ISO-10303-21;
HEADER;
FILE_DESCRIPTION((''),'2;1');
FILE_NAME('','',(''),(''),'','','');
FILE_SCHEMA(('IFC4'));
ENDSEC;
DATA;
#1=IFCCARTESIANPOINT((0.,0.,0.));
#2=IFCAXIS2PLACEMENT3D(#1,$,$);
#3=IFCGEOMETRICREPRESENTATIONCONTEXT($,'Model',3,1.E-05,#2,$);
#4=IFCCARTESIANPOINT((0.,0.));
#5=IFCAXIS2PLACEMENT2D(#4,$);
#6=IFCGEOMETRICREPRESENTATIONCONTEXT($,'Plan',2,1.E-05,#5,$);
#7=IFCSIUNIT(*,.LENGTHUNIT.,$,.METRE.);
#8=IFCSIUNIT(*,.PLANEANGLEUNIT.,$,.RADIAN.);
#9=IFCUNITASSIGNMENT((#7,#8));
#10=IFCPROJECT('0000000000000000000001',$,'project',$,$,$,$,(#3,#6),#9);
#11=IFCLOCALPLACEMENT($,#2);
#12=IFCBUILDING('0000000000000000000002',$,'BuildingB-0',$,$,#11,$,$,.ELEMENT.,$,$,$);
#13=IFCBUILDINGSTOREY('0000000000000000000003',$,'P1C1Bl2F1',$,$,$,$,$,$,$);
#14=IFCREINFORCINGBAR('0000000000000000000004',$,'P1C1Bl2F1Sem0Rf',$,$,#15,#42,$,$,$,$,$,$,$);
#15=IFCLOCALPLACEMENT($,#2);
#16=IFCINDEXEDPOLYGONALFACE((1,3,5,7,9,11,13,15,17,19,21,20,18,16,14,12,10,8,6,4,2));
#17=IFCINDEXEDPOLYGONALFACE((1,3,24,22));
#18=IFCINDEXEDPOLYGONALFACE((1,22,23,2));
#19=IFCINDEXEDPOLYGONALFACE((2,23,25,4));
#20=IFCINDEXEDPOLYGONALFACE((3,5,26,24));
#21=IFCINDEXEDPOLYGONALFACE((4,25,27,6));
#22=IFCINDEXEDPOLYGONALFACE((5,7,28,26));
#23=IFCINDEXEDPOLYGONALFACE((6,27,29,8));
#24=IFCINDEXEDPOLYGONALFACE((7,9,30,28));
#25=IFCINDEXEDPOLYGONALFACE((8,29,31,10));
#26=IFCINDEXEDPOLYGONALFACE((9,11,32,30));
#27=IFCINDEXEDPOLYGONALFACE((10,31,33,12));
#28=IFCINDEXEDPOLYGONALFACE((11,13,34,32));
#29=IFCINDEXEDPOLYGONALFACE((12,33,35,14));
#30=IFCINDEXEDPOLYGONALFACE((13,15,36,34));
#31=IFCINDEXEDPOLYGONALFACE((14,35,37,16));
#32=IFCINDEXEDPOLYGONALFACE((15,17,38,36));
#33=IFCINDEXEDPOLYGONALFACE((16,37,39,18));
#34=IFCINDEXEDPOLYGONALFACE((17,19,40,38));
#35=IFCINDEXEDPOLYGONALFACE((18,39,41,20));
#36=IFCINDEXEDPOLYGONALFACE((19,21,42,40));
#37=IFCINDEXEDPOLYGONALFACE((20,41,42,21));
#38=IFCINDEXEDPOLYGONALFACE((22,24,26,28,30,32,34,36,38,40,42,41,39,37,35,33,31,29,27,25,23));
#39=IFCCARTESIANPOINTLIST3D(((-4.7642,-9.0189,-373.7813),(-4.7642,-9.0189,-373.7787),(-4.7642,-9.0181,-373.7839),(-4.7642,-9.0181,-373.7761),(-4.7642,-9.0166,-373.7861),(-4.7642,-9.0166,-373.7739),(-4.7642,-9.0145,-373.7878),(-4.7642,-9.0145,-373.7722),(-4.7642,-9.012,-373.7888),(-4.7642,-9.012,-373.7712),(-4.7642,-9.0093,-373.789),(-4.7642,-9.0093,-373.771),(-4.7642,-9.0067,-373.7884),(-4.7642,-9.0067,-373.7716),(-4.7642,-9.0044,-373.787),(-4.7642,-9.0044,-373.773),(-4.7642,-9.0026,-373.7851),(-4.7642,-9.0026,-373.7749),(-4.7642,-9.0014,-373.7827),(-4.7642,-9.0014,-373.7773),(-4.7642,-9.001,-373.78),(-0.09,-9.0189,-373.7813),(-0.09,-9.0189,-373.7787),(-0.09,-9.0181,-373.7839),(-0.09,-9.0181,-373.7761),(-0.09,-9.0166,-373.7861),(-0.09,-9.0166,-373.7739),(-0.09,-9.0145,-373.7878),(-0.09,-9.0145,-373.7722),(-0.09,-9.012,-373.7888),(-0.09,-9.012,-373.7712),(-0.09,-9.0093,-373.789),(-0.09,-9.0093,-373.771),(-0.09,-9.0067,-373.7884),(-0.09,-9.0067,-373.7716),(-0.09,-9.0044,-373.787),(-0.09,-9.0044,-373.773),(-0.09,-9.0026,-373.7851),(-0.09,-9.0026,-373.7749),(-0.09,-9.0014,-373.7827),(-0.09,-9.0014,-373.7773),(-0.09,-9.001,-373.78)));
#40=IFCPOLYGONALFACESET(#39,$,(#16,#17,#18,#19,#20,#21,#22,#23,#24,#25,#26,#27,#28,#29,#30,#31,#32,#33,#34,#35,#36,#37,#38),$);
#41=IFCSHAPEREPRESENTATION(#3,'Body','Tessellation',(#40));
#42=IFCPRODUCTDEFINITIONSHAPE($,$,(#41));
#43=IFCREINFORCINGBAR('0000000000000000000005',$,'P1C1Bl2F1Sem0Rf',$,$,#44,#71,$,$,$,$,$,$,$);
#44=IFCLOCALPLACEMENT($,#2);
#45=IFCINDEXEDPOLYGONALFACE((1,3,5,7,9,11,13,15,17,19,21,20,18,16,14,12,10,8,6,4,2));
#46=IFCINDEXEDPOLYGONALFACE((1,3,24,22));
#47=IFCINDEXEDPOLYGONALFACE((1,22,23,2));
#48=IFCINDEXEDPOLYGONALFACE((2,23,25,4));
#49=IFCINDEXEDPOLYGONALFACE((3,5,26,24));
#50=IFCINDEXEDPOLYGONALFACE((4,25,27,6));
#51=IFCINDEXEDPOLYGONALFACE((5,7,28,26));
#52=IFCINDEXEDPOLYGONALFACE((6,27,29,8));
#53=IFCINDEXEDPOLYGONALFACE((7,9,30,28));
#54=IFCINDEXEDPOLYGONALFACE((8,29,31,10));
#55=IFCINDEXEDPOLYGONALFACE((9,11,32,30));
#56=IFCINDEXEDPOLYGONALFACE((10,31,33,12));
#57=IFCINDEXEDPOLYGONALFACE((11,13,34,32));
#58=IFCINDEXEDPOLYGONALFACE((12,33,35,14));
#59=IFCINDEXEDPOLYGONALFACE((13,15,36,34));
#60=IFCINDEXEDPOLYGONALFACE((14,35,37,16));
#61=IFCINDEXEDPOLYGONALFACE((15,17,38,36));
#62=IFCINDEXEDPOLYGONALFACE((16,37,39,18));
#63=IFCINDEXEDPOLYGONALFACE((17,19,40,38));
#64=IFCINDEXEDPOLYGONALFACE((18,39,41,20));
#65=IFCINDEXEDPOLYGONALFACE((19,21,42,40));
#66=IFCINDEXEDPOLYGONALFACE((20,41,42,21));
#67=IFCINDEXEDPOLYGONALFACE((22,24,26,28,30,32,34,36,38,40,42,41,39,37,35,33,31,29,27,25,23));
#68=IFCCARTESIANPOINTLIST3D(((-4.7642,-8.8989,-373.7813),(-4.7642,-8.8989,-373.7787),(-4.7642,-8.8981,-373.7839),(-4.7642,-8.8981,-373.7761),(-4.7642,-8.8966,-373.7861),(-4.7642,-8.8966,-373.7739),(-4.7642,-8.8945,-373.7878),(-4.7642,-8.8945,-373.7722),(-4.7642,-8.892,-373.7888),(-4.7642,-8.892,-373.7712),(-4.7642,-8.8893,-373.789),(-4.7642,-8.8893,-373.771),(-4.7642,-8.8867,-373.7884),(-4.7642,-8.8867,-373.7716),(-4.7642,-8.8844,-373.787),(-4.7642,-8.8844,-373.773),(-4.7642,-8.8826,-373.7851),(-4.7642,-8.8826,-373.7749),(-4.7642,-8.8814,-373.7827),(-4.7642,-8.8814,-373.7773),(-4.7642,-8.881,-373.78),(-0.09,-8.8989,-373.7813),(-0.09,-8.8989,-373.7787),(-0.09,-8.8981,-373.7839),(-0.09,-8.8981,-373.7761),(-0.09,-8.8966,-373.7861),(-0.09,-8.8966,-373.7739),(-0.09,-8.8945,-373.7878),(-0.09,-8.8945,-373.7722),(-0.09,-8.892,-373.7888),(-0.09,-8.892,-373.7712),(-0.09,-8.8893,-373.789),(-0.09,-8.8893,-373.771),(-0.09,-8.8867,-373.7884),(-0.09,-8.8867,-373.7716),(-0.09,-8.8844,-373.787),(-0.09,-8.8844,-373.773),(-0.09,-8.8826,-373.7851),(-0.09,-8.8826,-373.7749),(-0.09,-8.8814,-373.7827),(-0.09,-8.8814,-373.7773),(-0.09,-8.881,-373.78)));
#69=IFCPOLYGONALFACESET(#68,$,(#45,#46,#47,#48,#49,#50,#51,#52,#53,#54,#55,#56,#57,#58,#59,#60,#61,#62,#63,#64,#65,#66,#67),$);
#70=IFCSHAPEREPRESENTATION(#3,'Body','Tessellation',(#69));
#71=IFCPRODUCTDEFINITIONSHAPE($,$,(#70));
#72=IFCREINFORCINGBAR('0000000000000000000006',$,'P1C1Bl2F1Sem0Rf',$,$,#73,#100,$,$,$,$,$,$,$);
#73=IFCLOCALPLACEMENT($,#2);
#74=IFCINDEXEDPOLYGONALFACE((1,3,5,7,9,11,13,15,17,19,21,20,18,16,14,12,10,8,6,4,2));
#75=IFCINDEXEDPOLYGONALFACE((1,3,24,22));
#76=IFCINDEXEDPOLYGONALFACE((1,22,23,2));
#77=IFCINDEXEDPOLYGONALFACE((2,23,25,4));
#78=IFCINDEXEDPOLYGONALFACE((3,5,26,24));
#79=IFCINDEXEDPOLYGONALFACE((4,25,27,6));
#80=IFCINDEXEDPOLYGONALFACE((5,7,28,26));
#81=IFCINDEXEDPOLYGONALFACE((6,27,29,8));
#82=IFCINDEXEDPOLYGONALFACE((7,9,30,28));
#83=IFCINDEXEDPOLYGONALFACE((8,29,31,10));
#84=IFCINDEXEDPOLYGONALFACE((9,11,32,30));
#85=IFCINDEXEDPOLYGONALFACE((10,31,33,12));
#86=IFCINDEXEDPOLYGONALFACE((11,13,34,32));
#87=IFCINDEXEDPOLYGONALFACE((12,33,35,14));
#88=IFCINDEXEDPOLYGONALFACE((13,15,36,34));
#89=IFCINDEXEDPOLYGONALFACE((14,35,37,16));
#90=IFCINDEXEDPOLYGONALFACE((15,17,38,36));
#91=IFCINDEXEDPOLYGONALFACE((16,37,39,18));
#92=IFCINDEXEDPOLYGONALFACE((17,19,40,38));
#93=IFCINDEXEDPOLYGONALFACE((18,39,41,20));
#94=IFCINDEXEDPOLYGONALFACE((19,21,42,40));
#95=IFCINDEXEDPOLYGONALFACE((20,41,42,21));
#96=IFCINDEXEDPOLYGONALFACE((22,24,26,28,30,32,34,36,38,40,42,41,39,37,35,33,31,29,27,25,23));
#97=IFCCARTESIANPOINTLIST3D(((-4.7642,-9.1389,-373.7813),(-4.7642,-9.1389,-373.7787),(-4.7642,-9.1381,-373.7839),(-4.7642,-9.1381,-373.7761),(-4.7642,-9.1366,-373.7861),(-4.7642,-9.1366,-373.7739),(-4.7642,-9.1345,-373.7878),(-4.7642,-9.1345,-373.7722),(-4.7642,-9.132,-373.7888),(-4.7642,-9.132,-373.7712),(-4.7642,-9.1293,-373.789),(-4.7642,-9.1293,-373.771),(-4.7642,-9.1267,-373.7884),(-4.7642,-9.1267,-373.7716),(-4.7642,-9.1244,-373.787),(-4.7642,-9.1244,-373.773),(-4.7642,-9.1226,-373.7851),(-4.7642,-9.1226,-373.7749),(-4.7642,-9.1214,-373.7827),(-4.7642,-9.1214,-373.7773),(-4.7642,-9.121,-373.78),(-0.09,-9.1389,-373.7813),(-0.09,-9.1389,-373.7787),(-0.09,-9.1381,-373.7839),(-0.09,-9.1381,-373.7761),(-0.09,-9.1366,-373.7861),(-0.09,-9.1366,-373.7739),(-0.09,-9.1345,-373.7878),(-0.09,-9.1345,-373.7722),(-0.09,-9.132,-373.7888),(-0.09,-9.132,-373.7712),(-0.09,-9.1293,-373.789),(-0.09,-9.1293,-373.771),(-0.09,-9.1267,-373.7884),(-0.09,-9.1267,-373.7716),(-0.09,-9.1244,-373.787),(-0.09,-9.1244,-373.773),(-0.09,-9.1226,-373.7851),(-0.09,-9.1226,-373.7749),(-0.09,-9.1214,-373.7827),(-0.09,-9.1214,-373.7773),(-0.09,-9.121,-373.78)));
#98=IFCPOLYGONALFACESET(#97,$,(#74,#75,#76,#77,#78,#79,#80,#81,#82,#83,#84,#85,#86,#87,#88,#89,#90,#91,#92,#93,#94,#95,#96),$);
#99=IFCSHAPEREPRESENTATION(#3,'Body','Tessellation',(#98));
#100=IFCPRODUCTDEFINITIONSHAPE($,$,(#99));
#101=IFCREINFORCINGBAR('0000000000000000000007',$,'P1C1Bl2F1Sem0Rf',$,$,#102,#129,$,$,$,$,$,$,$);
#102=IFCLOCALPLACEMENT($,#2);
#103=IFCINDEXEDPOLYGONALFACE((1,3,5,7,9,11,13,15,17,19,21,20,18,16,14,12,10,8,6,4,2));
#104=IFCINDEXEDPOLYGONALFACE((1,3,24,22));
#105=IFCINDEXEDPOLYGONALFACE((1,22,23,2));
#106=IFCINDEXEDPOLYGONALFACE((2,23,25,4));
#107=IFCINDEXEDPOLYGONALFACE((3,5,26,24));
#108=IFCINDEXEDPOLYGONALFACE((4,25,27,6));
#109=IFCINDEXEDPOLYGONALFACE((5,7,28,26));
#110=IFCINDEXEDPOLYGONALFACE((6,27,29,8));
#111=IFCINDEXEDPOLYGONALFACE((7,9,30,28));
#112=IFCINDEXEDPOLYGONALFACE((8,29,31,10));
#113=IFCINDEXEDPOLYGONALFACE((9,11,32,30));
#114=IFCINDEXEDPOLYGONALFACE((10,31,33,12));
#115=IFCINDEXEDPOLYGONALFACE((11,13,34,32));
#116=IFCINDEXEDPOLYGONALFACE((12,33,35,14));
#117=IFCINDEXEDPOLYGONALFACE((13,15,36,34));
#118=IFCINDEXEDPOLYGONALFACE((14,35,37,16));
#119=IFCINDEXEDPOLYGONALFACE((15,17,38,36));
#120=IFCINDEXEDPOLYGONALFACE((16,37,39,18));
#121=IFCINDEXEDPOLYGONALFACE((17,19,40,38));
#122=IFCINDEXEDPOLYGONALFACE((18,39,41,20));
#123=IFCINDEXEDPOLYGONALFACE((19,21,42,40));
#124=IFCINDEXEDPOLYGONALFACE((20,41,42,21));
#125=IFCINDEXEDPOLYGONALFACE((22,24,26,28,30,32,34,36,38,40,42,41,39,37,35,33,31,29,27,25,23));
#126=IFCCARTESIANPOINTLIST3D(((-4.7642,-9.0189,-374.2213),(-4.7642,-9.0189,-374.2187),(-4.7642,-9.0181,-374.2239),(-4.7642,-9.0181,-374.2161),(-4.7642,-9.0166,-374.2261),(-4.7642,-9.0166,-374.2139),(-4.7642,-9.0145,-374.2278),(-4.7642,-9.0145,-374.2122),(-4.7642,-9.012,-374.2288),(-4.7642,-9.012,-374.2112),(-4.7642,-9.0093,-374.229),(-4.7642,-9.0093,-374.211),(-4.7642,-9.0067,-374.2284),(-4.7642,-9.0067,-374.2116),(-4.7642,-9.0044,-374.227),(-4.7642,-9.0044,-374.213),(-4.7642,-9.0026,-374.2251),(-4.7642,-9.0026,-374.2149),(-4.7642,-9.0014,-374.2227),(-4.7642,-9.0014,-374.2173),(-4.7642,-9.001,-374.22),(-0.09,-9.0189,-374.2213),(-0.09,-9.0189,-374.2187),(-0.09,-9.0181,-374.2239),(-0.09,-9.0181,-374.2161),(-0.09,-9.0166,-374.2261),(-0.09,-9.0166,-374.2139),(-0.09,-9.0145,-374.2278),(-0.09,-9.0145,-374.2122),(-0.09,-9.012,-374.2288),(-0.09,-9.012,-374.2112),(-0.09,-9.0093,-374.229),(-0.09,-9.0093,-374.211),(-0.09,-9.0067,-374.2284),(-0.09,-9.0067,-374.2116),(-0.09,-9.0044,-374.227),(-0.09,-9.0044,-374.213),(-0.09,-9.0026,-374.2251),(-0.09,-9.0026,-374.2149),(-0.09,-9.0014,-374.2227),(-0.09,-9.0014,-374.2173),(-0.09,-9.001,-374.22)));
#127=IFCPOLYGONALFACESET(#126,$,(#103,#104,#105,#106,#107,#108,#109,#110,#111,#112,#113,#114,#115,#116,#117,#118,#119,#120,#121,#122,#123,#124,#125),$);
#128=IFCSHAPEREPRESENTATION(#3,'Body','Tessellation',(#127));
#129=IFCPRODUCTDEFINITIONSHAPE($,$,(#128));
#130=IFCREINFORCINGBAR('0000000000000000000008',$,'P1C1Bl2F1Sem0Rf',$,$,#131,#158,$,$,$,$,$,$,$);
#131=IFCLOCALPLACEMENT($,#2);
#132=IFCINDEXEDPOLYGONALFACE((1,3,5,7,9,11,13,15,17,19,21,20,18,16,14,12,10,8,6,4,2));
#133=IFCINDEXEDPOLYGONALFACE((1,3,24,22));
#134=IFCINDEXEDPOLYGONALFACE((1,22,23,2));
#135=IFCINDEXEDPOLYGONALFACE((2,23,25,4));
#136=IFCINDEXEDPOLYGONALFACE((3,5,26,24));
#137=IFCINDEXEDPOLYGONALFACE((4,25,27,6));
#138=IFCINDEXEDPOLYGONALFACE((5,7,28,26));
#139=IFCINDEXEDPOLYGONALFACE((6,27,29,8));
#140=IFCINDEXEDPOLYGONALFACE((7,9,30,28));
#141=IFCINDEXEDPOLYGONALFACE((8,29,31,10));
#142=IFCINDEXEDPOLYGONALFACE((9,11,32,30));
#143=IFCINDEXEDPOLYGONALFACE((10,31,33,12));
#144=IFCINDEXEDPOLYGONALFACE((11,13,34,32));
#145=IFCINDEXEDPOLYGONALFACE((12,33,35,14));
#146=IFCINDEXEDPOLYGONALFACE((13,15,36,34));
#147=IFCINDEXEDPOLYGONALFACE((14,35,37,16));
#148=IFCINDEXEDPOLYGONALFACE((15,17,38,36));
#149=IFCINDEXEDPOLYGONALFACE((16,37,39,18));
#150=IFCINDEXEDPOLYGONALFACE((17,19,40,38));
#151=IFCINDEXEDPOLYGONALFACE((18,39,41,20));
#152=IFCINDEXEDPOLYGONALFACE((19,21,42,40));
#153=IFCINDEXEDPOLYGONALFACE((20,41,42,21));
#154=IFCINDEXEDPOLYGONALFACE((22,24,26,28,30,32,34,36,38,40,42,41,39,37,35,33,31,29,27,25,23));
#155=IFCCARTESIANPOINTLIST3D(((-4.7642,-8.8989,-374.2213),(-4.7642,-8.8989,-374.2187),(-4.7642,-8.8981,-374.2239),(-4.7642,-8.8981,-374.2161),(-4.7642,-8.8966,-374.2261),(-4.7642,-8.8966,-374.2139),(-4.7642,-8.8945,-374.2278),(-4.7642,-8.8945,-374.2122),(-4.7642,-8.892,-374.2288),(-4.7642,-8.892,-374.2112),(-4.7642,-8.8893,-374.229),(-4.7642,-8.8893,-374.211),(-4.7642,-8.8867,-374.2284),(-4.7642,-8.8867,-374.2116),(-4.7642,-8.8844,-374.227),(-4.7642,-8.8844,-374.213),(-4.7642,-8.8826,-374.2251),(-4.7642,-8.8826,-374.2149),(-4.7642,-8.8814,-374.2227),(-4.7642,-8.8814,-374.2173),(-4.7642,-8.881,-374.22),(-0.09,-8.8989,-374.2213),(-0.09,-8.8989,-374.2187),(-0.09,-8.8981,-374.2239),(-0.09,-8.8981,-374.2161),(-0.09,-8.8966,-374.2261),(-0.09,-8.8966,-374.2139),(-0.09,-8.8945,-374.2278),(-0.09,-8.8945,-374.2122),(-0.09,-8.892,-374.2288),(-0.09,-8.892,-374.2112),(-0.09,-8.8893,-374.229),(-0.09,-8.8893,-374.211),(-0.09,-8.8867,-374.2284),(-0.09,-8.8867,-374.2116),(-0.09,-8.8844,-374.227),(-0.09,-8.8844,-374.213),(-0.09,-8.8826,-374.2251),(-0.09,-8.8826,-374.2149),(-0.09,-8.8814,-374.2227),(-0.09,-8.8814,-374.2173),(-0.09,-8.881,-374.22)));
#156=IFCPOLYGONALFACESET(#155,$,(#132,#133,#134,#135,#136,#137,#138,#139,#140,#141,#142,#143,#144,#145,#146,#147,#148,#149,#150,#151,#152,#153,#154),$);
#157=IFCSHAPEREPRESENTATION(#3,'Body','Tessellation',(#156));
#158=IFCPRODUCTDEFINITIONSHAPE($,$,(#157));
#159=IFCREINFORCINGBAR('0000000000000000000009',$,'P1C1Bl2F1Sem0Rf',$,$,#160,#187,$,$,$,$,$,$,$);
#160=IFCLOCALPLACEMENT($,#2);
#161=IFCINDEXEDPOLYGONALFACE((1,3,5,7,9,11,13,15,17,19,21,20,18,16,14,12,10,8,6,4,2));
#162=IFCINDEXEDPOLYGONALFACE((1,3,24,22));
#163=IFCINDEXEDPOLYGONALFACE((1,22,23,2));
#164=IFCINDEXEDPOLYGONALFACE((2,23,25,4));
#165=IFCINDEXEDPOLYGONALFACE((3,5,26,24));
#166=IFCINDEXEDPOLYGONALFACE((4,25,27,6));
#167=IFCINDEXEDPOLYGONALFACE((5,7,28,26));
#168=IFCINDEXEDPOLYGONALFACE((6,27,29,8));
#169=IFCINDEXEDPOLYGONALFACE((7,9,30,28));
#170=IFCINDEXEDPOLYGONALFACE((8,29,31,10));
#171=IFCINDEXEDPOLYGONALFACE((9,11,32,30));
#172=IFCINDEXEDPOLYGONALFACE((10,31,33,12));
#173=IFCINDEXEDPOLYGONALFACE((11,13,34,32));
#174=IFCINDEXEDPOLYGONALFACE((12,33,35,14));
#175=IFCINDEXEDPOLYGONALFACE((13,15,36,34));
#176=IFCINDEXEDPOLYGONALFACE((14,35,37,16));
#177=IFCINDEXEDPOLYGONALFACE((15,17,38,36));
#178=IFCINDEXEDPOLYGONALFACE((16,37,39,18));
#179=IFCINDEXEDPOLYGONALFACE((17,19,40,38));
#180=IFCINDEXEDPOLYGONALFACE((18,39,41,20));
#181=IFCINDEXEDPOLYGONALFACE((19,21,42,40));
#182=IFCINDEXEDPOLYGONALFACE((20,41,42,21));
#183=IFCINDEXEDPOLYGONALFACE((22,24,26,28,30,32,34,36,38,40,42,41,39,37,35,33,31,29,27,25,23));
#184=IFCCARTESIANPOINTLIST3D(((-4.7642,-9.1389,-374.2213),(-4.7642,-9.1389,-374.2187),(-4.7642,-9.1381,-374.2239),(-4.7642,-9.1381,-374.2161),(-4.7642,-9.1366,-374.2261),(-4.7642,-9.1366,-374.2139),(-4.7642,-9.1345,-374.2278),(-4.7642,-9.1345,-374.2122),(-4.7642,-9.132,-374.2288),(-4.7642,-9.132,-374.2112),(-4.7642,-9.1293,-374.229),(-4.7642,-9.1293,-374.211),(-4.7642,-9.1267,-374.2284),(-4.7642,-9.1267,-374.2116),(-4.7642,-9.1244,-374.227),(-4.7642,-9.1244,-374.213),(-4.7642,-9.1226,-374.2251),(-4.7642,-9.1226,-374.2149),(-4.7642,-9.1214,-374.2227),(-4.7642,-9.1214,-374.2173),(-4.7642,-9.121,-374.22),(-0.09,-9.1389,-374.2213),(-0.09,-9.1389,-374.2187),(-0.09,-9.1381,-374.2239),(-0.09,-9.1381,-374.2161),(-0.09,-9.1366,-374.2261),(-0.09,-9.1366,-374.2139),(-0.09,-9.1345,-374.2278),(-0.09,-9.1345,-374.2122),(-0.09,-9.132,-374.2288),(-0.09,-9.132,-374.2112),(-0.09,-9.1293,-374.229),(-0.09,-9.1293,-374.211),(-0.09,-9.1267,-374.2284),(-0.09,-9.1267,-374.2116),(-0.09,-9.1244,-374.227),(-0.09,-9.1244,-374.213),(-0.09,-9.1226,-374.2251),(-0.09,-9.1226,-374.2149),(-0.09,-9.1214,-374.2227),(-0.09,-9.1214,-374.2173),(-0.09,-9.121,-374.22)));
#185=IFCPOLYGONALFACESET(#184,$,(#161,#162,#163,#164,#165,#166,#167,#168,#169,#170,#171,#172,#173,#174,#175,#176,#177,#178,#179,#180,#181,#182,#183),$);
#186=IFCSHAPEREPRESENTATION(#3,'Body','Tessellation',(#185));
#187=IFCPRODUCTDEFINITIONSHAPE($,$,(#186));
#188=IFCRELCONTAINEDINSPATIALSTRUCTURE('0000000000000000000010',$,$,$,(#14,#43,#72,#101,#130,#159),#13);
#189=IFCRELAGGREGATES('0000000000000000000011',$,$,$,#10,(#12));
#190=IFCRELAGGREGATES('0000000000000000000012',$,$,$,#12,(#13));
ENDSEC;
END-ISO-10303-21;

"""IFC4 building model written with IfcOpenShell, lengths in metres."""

from ifc_helpers import new_model, entity, si_unit, origin, origin_2d, place, context, project, spatial, element, save


model = new_model("IFC4")

# Units and contexts
model_context = context("Model", 3, precision=1e-05, world=origin())
plan_context = context("Plan", 2, precision=1e-05, world=origin_2d())
ifc_project = project(units=[si_unit("LENGTHUNIT", "METRE"), si_unit("PLANEANGLEUNIT", "RADIAN")], contexts=[model_context, plan_context])

# Building, storey
building_placement = place(None, origin())
building = spatial("IfcBuilding", under=ifc_project, at=building_placement, Name="BuildingB-0", CompositionType="ELEMENT")
storey = spatial("IfcBuildingStorey", under=building, Name="P1C1Bl2F1")

# Reinforcing bars
element("IfcReinforcingBar", 1, inside=storey, Name="P1C1Bl2F1Sem0Rf", context=model_context, shape_type="SweptSolid", body=[
    entity("IfcSurfaceCurveSweptAreaSolid", entity("IfcCircleProfileDef", "AREA", None, None, 0.009), None, entity("IfcPolyline", [entity("IfcCartesianPoint", [0.09, 9.01, 373.78]), entity("IfcCartesianPoint", [4.7642, 9.01, 373.78])]), None, None, entity("IfcPlane", entity("IfcAxis2Placement3D", entity("IfcCartesianPoint", [0.09, 9.01, 373.78]), entity("IfcDirection", [0.0, 0.0, 1.0]), entity("IfcDirection", [1.0, 0.0, 0.0])))),
])
element("IfcReinforcingBar", 2, inside=storey, Name="P1C1Bl2F1Sem0Rf", context=model_context, shape_type="SweptSolid", body=[
    entity("IfcSurfaceCurveSweptAreaSolid", entity("IfcCircleProfileDef", "AREA", None, None, 0.009), None, entity("IfcPolyline", [entity("IfcCartesianPoint", [0.09, 8.89, 373.78]), entity("IfcCartesianPoint", [4.7642, 8.89, 373.78])]), None, None, entity("IfcPlane", entity("IfcAxis2Placement3D", entity("IfcCartesianPoint", [0.09, 8.89, 373.78]), entity("IfcDirection", [0.0, 0.0, 1.0]), entity("IfcDirection", [1.0, 0.0, 0.0])))),
])
element("IfcReinforcingBar", 3, inside=storey, Name="P1C1Bl2F1Sem0Rf", context=model_context, shape_type="SweptSolid", body=[
    entity("IfcSurfaceCurveSweptAreaSolid", entity("IfcCircleProfileDef", "AREA", None, None, 0.009), None, entity("IfcPolyline", [entity("IfcCartesianPoint", [0.09, 9.13, 373.78]), entity("IfcCartesianPoint", [4.7642, 9.13, 373.78])]), None, None, entity("IfcPlane", entity("IfcAxis2Placement3D", entity("IfcCartesianPoint", [0.09, 9.13, 373.78]), entity("IfcDirection", [0.0, 0.0, 1.0]), entity("IfcDirection", [1.0, 0.0, 0.0])))),
])
element("IfcReinforcingBar", 4, inside=storey, Name="P1C1Bl2F1Sem0Rf", context=model_context, shape_type="SweptSolid", body=[
    entity("IfcSurfaceCurveSweptAreaSolid", entity("IfcCircleProfileDef", "AREA", None, None, 0.009), None, entity("IfcPolyline", [entity("IfcCartesianPoint", [0.09, 9.01, 374.22]), entity("IfcCartesianPoint", [4.7642, 9.01, 374.22])]), None, None, entity("IfcPlane", entity("IfcAxis2Placement3D", entity("IfcCartesianPoint", [0.09, 9.01, 374.22]), entity("IfcDirection", [0.0, 0.0, 1.0]), entity("IfcDirection", [1.0, 0.0, 0.0])))),
])
element("IfcReinforcingBar", 5, inside=storey, Name="P1C1Bl2F1Sem0Rf", context=model_context, shape_type="SweptSolid", body=[
    entity("IfcSurfaceCurveSweptAreaSolid", entity("IfcCircleProfileDef", "AREA", None, None, 0.009), None, entity("IfcPolyline", [entity("IfcCartesianPoint", [0.09, 8.89, 374.22]), entity("IfcCartesianPoint", [4.7642, 8.89, 374.22])]), None, None, entity("IfcPlane", entity("IfcAxis2Placement3D", entity("IfcCartesianPoint", [0.09, 8.89, 374.22]), entity("IfcDirection", [0.0, 0.0, 1.0]), entity("IfcDirection", [1.0, 0.0, 0.0])))),
])
element("IfcReinforcingBar", 6, inside=storey, Name="P1C1Bl2F1Sem0Rf", context=model_context, shape_type="SweptSolid", body=[
    entity("IfcSurfaceCurveSweptAreaSolid", entity("IfcCircleProfileDef", "AREA", None, None, 0.009), None, entity("IfcPolyline", [entity("IfcCartesianPoint", [0.09, 9.13, 374.22]), entity("IfcCartesianPoint", [4.7642, 9.13, 374.22])]), None, None, entity("IfcPlane", entity("IfcAxis2Placement3D", entity("IfcCartesianPoint", [0.09, 9.13, 374.22]), entity("IfcDirection", [0.0, 0.0, 1.0]), entity("IfcDirection", [1.0, 0.0, 0.0])))),
])

save(model, "model.ifc")
